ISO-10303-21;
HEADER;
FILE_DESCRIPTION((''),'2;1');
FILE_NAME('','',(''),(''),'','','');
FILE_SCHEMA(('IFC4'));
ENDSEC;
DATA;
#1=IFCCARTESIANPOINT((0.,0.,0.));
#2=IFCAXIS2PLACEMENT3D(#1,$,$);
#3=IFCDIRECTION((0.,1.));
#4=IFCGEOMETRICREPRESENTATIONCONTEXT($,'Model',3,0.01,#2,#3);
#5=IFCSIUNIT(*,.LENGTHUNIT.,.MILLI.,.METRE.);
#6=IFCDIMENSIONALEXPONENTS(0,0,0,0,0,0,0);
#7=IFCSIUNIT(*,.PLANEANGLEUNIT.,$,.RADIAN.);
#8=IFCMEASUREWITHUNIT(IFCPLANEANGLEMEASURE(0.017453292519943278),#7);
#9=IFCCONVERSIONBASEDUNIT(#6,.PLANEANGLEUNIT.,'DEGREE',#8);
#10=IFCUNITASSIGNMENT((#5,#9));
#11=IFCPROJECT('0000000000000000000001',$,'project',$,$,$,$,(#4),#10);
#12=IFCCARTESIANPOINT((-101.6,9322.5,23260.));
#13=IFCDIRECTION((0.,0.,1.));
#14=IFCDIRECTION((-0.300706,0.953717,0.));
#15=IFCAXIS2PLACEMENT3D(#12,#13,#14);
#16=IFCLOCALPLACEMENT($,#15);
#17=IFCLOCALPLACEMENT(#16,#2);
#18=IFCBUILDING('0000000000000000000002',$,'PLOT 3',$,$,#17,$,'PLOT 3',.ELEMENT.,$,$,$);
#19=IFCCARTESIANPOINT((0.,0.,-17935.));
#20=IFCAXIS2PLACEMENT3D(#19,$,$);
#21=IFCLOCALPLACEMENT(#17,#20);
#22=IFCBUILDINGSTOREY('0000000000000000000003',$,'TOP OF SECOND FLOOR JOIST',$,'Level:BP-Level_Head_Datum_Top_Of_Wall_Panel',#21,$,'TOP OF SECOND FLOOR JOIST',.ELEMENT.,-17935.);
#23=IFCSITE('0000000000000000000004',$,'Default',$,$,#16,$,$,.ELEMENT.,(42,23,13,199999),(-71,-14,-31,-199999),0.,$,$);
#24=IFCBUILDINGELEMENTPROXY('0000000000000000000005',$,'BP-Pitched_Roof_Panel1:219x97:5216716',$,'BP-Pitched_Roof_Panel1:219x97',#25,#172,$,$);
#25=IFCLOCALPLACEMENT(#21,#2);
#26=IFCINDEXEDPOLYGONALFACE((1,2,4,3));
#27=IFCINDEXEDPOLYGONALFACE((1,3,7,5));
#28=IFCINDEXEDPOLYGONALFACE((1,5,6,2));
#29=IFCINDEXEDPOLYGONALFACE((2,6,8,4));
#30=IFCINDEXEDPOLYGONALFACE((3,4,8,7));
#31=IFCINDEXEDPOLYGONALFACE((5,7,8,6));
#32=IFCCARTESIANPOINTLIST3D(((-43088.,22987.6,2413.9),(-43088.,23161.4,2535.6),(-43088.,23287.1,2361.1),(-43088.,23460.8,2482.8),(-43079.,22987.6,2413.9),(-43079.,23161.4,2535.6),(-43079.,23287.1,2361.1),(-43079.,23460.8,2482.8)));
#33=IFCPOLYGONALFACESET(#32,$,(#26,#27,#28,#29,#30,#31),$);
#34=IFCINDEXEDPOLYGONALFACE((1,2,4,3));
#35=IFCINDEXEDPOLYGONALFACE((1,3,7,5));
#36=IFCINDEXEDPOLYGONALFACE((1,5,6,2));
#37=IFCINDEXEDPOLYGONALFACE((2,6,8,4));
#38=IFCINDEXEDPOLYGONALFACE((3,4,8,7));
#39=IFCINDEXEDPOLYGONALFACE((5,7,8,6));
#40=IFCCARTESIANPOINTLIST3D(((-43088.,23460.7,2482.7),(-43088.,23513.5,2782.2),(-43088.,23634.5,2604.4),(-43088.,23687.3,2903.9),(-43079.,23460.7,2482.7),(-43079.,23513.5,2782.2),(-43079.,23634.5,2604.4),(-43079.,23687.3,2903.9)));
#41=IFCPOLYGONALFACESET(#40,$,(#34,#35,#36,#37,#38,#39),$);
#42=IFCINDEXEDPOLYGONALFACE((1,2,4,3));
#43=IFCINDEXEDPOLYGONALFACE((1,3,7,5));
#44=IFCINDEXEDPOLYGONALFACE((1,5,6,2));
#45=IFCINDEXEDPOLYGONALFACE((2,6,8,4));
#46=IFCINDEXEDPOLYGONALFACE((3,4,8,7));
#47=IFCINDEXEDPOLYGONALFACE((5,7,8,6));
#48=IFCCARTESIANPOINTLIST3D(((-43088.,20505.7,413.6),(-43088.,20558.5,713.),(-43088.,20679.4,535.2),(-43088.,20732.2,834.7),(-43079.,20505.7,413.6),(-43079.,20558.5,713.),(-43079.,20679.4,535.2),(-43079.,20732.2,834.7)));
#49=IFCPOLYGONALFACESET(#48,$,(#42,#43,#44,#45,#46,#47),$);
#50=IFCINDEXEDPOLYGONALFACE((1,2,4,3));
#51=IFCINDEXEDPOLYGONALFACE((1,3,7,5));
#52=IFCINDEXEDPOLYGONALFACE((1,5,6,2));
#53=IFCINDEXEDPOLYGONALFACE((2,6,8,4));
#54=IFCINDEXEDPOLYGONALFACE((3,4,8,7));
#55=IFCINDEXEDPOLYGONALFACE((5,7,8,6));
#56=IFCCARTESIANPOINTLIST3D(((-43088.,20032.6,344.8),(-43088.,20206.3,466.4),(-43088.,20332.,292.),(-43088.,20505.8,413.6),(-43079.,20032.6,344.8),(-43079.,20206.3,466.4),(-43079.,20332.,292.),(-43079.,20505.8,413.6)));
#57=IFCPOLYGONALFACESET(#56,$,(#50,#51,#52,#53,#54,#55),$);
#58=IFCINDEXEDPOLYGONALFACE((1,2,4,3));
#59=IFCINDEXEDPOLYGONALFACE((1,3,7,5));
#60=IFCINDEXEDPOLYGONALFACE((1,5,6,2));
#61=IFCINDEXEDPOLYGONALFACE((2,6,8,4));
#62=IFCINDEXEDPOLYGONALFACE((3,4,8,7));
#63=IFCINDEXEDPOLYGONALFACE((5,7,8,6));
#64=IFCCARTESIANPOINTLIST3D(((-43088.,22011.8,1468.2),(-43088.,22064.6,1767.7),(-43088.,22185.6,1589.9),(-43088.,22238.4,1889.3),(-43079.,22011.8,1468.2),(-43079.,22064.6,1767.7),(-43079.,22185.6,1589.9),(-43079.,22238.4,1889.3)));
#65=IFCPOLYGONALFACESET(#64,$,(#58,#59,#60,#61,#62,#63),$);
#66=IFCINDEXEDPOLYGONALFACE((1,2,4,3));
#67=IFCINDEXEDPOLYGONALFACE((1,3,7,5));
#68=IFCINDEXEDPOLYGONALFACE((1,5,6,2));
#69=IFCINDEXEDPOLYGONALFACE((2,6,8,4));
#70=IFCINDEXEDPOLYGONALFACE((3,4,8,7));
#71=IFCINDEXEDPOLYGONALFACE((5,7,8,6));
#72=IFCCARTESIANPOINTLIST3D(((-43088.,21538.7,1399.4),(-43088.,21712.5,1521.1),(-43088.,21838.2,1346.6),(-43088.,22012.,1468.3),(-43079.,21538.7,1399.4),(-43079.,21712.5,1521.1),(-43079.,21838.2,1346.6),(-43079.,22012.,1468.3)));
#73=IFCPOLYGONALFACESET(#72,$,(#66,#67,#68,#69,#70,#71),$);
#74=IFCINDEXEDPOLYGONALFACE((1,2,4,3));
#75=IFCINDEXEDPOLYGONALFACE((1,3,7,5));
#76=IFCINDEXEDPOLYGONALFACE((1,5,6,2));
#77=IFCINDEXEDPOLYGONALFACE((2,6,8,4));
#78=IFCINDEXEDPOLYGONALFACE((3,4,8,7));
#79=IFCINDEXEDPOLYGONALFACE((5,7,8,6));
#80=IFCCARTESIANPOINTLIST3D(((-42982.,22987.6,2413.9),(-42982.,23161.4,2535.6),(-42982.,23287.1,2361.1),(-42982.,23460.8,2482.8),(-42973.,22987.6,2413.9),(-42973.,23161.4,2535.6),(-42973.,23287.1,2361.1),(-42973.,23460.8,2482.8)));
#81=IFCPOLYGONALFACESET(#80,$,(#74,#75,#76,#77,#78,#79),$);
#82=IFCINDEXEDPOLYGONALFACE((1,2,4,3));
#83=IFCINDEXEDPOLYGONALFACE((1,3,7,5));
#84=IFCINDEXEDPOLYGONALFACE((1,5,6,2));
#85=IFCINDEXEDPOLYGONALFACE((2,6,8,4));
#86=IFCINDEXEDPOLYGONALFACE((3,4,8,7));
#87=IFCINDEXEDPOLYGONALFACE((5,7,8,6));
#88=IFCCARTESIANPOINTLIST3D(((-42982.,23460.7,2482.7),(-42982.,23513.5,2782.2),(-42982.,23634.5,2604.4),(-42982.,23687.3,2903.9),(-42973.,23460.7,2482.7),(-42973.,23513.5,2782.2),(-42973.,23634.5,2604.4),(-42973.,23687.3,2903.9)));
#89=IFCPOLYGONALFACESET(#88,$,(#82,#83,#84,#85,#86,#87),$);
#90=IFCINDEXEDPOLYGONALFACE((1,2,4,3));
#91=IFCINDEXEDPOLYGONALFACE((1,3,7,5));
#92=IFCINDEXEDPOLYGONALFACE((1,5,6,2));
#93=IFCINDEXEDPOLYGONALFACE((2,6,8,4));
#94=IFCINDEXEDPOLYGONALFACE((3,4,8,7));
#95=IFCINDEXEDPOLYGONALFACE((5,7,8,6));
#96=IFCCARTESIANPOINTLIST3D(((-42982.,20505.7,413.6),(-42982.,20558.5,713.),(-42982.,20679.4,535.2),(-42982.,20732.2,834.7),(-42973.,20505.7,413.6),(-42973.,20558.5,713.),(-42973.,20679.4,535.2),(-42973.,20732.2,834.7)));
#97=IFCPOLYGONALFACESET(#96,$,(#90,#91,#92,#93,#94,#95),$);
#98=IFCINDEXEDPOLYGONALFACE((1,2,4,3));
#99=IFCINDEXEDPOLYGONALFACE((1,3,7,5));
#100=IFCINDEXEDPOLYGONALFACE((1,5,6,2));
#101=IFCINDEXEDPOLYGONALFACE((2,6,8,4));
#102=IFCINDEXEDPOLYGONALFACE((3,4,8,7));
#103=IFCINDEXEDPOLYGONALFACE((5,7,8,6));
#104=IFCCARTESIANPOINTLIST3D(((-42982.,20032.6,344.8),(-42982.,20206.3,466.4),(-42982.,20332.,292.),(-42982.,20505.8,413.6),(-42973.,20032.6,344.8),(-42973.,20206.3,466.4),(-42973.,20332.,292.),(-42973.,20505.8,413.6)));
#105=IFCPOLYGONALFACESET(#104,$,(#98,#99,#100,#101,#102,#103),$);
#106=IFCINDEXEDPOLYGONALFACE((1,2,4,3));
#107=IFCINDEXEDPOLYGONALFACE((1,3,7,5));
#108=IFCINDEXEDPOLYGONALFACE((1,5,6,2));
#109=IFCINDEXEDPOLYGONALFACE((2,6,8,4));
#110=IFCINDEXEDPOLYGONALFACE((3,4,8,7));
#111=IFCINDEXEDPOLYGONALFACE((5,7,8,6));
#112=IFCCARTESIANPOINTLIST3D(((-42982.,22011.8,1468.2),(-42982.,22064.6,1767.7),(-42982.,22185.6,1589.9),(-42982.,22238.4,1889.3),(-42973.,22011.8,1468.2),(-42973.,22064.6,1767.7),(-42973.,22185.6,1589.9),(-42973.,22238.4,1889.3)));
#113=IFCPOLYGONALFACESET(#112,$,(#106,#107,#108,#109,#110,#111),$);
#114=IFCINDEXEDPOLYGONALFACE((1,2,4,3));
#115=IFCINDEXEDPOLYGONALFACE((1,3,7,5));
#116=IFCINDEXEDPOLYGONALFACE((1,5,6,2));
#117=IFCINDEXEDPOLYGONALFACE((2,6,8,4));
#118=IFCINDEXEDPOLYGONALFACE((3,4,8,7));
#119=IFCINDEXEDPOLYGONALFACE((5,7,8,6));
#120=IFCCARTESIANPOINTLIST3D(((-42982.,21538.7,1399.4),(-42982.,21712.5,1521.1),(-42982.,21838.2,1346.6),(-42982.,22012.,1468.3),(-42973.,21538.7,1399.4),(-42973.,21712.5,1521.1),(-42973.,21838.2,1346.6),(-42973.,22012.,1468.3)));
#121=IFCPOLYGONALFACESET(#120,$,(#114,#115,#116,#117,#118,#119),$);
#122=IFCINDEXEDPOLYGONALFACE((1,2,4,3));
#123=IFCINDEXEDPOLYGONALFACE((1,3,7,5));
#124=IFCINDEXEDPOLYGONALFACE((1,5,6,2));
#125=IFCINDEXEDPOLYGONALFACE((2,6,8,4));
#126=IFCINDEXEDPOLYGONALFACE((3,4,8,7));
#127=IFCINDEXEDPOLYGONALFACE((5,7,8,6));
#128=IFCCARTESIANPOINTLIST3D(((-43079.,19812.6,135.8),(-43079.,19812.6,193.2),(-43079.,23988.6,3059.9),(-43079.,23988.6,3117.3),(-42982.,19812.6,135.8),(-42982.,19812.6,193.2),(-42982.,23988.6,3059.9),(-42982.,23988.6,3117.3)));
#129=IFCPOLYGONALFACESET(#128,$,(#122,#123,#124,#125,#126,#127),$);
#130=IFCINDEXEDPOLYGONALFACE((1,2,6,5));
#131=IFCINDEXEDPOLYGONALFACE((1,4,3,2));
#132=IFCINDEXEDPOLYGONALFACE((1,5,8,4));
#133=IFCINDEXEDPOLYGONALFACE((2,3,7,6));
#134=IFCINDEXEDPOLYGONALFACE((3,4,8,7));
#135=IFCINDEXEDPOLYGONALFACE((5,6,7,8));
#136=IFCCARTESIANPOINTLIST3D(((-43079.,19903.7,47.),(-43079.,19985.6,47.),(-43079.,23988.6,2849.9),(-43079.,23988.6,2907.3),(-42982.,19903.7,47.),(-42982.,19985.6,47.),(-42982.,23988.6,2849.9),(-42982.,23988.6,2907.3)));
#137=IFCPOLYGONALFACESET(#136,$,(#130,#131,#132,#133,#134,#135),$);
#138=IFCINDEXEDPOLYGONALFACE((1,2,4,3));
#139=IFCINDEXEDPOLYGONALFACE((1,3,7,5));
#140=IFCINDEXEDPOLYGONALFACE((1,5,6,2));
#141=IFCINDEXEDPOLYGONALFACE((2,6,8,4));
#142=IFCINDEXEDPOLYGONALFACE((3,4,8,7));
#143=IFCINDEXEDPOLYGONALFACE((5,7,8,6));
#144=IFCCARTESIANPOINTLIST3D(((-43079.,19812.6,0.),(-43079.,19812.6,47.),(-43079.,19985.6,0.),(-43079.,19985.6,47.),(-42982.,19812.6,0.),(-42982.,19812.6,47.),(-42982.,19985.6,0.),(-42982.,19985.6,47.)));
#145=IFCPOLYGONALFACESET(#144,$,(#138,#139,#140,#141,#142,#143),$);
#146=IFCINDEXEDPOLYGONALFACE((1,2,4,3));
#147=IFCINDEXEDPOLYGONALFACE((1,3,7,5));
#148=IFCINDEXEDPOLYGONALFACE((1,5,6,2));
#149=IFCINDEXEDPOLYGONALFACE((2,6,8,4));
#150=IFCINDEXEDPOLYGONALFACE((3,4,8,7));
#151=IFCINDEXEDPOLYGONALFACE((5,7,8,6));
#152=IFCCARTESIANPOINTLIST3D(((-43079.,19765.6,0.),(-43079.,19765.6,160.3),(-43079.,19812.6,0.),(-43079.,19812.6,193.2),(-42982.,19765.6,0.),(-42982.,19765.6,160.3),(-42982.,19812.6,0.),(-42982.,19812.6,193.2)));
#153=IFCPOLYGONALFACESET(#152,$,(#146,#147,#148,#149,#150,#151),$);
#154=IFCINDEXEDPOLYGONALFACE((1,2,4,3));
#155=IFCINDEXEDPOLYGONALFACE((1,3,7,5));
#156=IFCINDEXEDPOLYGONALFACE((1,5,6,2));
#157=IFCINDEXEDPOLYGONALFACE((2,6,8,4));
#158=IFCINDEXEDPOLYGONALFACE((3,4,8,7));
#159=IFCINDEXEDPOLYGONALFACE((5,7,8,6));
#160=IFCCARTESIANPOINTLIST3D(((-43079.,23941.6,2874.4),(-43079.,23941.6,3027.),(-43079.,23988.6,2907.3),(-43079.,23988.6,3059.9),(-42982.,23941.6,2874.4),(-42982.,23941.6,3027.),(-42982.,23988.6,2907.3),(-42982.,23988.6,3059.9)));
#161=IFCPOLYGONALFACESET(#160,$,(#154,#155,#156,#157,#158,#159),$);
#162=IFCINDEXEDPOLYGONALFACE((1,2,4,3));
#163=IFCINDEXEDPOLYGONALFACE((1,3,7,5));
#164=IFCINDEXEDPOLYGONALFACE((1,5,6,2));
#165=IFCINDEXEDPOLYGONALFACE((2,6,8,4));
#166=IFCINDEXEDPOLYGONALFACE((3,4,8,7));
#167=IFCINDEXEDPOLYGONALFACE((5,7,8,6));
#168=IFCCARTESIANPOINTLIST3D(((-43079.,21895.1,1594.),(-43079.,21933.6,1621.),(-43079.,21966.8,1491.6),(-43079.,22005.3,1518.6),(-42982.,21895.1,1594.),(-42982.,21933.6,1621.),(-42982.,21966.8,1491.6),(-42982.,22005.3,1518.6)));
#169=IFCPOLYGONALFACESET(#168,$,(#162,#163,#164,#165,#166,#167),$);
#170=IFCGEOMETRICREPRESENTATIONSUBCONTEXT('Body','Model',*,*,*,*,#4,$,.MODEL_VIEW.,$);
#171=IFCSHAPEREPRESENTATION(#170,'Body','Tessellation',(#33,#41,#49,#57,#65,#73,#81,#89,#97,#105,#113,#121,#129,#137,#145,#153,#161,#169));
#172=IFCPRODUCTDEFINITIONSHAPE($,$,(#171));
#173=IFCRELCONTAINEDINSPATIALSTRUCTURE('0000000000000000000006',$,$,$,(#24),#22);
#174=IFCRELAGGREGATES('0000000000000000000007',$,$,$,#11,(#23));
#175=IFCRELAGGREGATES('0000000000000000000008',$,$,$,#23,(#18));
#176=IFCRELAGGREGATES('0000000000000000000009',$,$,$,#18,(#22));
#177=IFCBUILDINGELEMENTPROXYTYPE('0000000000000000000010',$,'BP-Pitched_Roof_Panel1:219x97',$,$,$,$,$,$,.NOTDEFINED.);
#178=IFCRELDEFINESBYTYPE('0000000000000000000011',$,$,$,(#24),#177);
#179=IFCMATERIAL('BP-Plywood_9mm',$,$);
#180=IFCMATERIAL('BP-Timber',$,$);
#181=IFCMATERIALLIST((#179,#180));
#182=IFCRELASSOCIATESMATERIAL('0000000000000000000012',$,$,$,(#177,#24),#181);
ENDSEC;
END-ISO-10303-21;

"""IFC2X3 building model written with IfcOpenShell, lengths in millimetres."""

from ifc_helpers import new_model, entity, si_unit, converted_unit, direction, frame, frame_2d, origin, origin_2d_with_axis, place, context, subcontext, project, spatial, polyline, rectangle, outline, extrude, source, transform, mapped, material, material_list, type_object, type_shapes, element, save


model = new_model("IFC2X3")

# Units and contexts
model_context = context("Model", 3, precision=0.01, world=origin(), true_north=direction((0.0, 1.0)))
body_context = subcontext(model_context, "Body", "Model", "MODEL_VIEW")
ifc_project = project(units=[si_unit("LENGTHUNIT", "METRE", prefix="MILLI"), converted_unit("PLANEANGLEUNIT", "DEGREE", entity("IfcPlaneAngleMeasure", 0.017453292519943278), si_unit("PLANEANGLEUNIT", "RADIAN"), dimensions=[0, 0, 0, 0, 0, 0, 0])], contexts=[model_context])

# Site, building, storey
site_placement = place(None, frame((-101.6, 9322.5, 23260.0), z_axis=(0.0, 0.0, 1.0), x_axis=(-0.300706, 0.953717, 0.0)))
site = spatial("IfcSite", under=ifc_project, at=site_placement, Name="Default", CompositionType="ELEMENT", RefLatitude=(42, 23, 13, 199999), RefLongitude=(-71, -14, -31, -199999), RefElevation=0.0)
building_placement = place(site_placement, origin())
building = spatial("IfcBuilding", under=site, at=building_placement, Name="PLOT 3", LongName="PLOT 3", CompositionType="ELEMENT")
storey_placement = place(building_placement, frame((0.0, 0.0, -17935.0)))
storey = spatial("IfcBuildingStorey", under=building, at=storey_placement, Name="TOP OF SECOND FLOOR JOIST", ObjectType="Level:BP-Level_Head_Datum_Top_Of_Wall_Panel", LongName="TOP OF SECOND FLOOR JOIST", CompositionType="ELEMENT", Elevation=-17935.0)

# Building element proxy
ifc_material_1 = material(Name="BP-Timber")
ifc_material_2 = material(Name="BP-Plywood_9mm")
ifc_material_list = material_list([ifc_material_2, ifc_material_1])
building_element_proxy_type_1 = type_object("IfcBuildingElementProxyType", Name="BP-Pitched_Roof_Panel1:219x97", PredefinedType="NOTDEFINED", material=ifc_material_list)
shared_shape_1 = source(origin(), body_context, "Body", "SweptSolid", [
    extrude(outline(polyline([(-77.0, -75.0), (227.0, -75.0), (77.0, 75.0), (-227.0, 75.0), (-77.0, -75.0)])), frame((36.3, 3947.0, 2448.4), z_axis=(0.0, 1.0, 0.0), x_axis=(-0.984808, 0.0, 0.173648)), (0.0, 0.0, 1.0), 9.0),
    extrude(outline(polyline([(1.4, -107.5), (213.6, -107.5), (-1.4, 107.5), (-213.6, 107.5), (1.4, -107.5)])), frame((386.1, 3947.0, 2693.3), z_axis=(0.0, 1.0, 0.0), x_axis=(-0.819152, 0.0, -0.573576)), (0.0, 0.0, 1.0), 9.0),
    extrude(outline(polyline([(1.4, -107.5), (213.6, -107.5), (-1.4, 107.5), (-213.6, 107.5), (1.4, -107.5)])), frame((-2569.0, 3947.0, 624.1), z_axis=(0.0, 1.0, 0.0), x_axis=(-0.819152, 0.0, -0.573576)), (0.0, 0.0, 1.0), 9.0),
    extrude(outline(polyline([(-77.0, -75.0), (227.0, -75.0), (77.0, 75.0), (-227.0, 75.0), (-77.0, -75.0)])), frame((-2918.8, 3947.0, 379.2), z_axis=(0.0, 1.0, 0.0), x_axis=(-0.984808, 0.0, 0.173648)), (0.0, 0.0, 1.0), 9.0),
    extrude(outline(polyline([(1.4, -107.5), (213.6, -107.5), (-1.4, 107.5), (-213.6, 107.5), (1.4, -107.5)])), frame((-1062.8, 3947.0, 1678.8), z_axis=(0.0, 1.0, 0.0), x_axis=(-0.819152, 0.0, -0.573576)), (0.0, 0.0, 1.0), 9.0),
    extrude(outline(polyline([(-77.0, -75.0), (227.0, -75.0), (77.0, 75.0), (-227.0, 75.0), (-77.0, -75.0)])), frame((-1412.6, 3947.0, 1433.9), z_axis=(0.0, 1.0, 0.0), x_axis=(-0.984808, 0.0, 0.173648)), (0.0, 0.0, 1.0), 9.0),
    extrude(outline(polyline([(-77.0, -75.0), (227.0, -75.0), (77.0, 75.0), (-227.0, 75.0), (-77.0, -75.0)])), frame((36.3, 3841.0, 2448.4), z_axis=(0.0, 1.0, 0.0), x_axis=(-0.984808, 0.0, 0.173648)), (0.0, 0.0, 1.0), 9.0),
    extrude(outline(polyline([(1.4, -107.5), (213.6, -107.5), (-1.4, 107.5), (-213.6, 107.5), (1.4, -107.5)])), frame((386.1, 3841.0, 2693.3), z_axis=(0.0, 1.0, 0.0), x_axis=(-0.819152, 0.0, -0.573576)), (0.0, 0.0, 1.0), 9.0),
    extrude(outline(polyline([(1.4, -107.5), (213.6, -107.5), (-1.4, 107.5), (-213.6, 107.5), (1.4, -107.5)])), frame((-2569.0, 3841.0, 624.1), z_axis=(0.0, 1.0, 0.0), x_axis=(-0.819152, 0.0, -0.573576)), (0.0, 0.0, 1.0), 9.0),
    extrude(outline(polyline([(-77.0, -75.0), (227.0, -75.0), (77.0, 75.0), (-227.0, 75.0), (-77.0, -75.0)])), frame((-2918.8, 3841.0, 379.2), z_axis=(0.0, 1.0, 0.0), x_axis=(-0.984808, 0.0, 0.173648)), (0.0, 0.0, 1.0), 9.0),
    extrude(outline(polyline([(1.4, -107.5), (213.6, -107.5), (-1.4, 107.5), (-213.6, 107.5), (1.4, -107.5)])), frame((-1062.8, 3841.0, 1678.8), z_axis=(0.0, 1.0, 0.0), x_axis=(-0.819152, 0.0, -0.573576)), (0.0, 0.0, 1.0), 9.0),
    extrude(outline(polyline([(-77.0, -75.0), (227.0, -75.0), (77.0, 75.0), (-227.0, 75.0), (-77.0, -75.0)])), frame((-1412.6, 3841.0, 1433.9), z_axis=(0.0, 1.0, 0.0), x_axis=(-0.984808, 0.0, 0.173648)), (0.0, 0.0, 1.0), 9.0),
    extrude(outline(polyline([(-1490.7, -2088.0), (-1433.3, -2088.0), (1490.7, 2088.0), (1433.3, 2088.0), (-1490.7, -2088.0)])), frame((-1287.3, 3850.0, 1626.6), z_axis=(0.0, 1.0, 0.0), x_axis=(0.0, 0.0, -1.0)), (0.0, 0.0, 1.0), 97.0),
    extrude(outline(polyline([(-1444.5, -2022.0), (-1387.1, -2022.0), (1415.8, 1981.0), (1415.8, 2063.0), (-1444.5, -2022.0)])), frame((-1221.3, 3850.0, 1462.8), z_axis=(0.0, 1.0, 0.0), x_axis=(0.0, 0.0, -1.0)), (0.0, 0.0, 1.0), 97.0),
    extrude(rectangle(XDim=97.0, YDim=173.0, at=origin_2d_with_axis()), frame((-3288.8, 3898.5, 0.0), z_axis=(0.0, 0.0, 1.0), x_axis=(0.0, 1.0, 0.0)), (0.0, 0.0, 1.0), 47.0),
    extrude(outline(polyline([(22.0, -72.4), (79.4, -72.4), (-31.4, 85.9), (-69.9, 58.9), (22.0, -72.4)])), frame((-3398.8, 3850.0, 88.4), z_axis=(0.0, 1.0, 0.0), x_axis=(0.819152, 0.0, 0.573576)), (0.0, 0.0, 1.0), 97.0),
    extrude(outline(polyline([(15.1, -62.5), (72.5, -62.5), (-15.1, 62.5), (-72.5, 62.5), (15.1, -62.5)])), frame((777.2, 3850.0, 2967.2), z_axis=(0.0, 1.0, 0.0), x_axis=(0.819152, 0.0, 0.573576)), (0.0, 0.0, 1.0), 97.0),
    extrude(rectangle(XDim=47.0, YDim=97.0, at=frame_2d((0.0, 0.0), x_axis=(0.0, 1.0))), frame((-1201.9, 3898.5, 1505.1), z_axis=(-0.573576, 0.0, 0.819152), x_axis=(0.0, 1.0, 0.0)), (0.0, 0.0, 1.0), 125.0),
])
type_shapes(building_element_proxy_type_1, [shared_shape_1])
for number, where, z_axis, x_axis, name in (
    (1, (-39132.0, 23187.9, 0.0), (0.0, 0.0, 1.0), (0.0, 1.0, 0.0), "BP-Pitched_Roof_Panel1:219x97:5216716"),
):
    element("IfcBuildingElementProxy", number, at=place(storey_placement, frame(where, z_axis=z_axis, x_axis=x_axis)), inside=storey, type_object=building_element_proxy_type_1, material=ifc_material_list, Name=name, ObjectType="BP-Pitched_Roof_Panel1:219x97", context=body_context, shape_type="MappedRepresentation", body=[
        mapped(shared_shape_1, transform((0.0, 0.0, 0.0), scale=1.0)),
    ])

save(model, "model.ifc")
